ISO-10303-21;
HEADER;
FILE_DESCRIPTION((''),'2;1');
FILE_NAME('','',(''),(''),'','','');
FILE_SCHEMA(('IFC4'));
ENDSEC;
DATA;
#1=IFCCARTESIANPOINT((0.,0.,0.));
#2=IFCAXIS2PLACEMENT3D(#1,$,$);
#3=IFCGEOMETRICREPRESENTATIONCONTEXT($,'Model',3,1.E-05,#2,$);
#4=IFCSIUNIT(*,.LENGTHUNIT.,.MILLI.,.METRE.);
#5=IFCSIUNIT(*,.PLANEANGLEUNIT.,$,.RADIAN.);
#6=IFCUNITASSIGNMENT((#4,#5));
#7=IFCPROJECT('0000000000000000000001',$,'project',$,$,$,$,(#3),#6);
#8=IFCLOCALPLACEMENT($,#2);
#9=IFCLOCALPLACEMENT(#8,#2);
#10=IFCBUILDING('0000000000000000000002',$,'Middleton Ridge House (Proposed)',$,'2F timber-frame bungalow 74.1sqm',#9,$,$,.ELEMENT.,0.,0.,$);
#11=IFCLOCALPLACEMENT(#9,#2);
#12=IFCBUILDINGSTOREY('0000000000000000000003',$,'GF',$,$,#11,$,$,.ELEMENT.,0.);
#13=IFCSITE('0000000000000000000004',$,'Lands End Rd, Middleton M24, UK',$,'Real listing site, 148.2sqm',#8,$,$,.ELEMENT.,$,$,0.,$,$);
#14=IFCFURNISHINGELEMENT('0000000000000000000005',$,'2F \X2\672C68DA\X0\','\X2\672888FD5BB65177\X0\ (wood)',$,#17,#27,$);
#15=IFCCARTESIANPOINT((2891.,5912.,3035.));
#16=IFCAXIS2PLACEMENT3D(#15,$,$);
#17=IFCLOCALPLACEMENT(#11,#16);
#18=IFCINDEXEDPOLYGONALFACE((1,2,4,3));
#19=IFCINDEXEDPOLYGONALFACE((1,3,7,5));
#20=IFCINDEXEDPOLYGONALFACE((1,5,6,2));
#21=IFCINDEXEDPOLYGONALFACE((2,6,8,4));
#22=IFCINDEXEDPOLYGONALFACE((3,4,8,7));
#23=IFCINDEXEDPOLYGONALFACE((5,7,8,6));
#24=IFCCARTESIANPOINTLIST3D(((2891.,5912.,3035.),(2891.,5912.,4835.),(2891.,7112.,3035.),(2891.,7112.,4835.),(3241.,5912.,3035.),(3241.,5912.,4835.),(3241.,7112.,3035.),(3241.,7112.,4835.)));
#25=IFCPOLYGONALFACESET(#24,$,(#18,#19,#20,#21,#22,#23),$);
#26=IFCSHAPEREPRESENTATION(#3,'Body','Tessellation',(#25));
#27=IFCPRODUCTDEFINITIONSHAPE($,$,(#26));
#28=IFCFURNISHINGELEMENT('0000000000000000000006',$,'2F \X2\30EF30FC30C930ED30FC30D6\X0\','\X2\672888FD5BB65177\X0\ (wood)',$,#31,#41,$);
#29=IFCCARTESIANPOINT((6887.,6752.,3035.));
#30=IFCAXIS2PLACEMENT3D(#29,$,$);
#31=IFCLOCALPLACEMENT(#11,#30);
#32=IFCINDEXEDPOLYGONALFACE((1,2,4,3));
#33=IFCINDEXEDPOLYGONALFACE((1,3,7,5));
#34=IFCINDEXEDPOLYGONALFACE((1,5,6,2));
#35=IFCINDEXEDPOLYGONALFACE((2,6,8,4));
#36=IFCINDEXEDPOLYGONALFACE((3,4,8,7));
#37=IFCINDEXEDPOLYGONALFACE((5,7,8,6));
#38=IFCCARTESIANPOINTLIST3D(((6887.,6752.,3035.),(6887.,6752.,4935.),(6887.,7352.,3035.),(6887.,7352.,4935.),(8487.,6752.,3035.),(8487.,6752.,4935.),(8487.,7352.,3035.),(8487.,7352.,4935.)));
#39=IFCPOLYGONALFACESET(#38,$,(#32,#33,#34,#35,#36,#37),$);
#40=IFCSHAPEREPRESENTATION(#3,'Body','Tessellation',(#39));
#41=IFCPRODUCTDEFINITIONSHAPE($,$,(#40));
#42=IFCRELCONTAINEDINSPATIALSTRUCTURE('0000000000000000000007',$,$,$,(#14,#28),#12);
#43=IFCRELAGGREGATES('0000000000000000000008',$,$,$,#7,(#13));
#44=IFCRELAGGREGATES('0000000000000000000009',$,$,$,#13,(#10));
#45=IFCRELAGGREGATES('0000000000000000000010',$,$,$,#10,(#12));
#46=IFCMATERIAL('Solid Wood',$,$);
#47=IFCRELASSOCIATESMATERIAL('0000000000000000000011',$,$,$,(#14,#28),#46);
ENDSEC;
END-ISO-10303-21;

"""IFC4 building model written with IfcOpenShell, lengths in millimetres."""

from ifc_helpers import new_model, si_unit, frame, frame_2d, origin, place, context, project, spatial, rectangle, extrude, material, element, save


model = new_model("IFC4")

# Units and contexts
model_context = context("Model", 3, precision=1e-05, world=origin())
ifc_project = project(units=[si_unit("LENGTHUNIT", "METRE", prefix="MILLI"), si_unit("PLANEANGLEUNIT", "RADIAN")], contexts=[model_context])

# Site, building, storey
site_placement = place(None, origin())
site = spatial("IfcSite", under=ifc_project, at=site_placement, Name="Lands End Rd, Middleton M24, UK", ObjectType="Real listing site, 148.2sqm", CompositionType="ELEMENT", RefElevation=0.0)
building_placement = place(site_placement, origin())
building = spatial("IfcBuilding", under=site, at=building_placement, Name="Middleton Ridge House (Proposed)", ObjectType="2F timber-frame bungalow 74.1sqm", CompositionType="ELEMENT", ElevationOfRefHeight=0.0, ElevationOfTerrain=0.0)
storey_placement = place(building_placement, origin())
storey = spatial("IfcBuildingStorey", under=building, at=storey_placement, Name="GF", CompositionType="ELEMENT", Elevation=0.0)

# Shared definitions
ifc_material_1 = material(Name="Solid Wood")

# Furnishing elements
furnishing_1_placement = place(storey_placement, frame((2891.0, 5912.0, 3035.0)))
element("IfcFurnishingElement", 1, at=furnishing_1_placement, inside=storey, material=ifc_material_1, Name="2F 本棚", Description="木製家具 (wood)", context=model_context, shape_type="SweptSolid", body=[
    extrude(rectangle(XDim=350.0, YDim=1200.0, at=frame_2d((175.0, 600.0))), frame((2891.0, 5912.0, 3035.0)), (0.0, 0.0, 1.0), 1800.0),
])
furnishing_2_placement = place(storey_placement, frame((6887.0, 6752.0, 3035.0)))
element("IfcFurnishingElement", 2, at=furnishing_2_placement, inside=storey, material=ifc_material_1, Name="2F ワードローブ", Description="木製家具 (wood)", context=model_context, shape_type="SweptSolid", body=[
    extrude(rectangle(XDim=1600.0, YDim=600.0, at=frame_2d((800.0, 300.0))), frame((6887.0, 6752.0, 3035.0)), (0.0, 0.0, 1.0), 1900.0),
])

save(model, "model.ifc")
